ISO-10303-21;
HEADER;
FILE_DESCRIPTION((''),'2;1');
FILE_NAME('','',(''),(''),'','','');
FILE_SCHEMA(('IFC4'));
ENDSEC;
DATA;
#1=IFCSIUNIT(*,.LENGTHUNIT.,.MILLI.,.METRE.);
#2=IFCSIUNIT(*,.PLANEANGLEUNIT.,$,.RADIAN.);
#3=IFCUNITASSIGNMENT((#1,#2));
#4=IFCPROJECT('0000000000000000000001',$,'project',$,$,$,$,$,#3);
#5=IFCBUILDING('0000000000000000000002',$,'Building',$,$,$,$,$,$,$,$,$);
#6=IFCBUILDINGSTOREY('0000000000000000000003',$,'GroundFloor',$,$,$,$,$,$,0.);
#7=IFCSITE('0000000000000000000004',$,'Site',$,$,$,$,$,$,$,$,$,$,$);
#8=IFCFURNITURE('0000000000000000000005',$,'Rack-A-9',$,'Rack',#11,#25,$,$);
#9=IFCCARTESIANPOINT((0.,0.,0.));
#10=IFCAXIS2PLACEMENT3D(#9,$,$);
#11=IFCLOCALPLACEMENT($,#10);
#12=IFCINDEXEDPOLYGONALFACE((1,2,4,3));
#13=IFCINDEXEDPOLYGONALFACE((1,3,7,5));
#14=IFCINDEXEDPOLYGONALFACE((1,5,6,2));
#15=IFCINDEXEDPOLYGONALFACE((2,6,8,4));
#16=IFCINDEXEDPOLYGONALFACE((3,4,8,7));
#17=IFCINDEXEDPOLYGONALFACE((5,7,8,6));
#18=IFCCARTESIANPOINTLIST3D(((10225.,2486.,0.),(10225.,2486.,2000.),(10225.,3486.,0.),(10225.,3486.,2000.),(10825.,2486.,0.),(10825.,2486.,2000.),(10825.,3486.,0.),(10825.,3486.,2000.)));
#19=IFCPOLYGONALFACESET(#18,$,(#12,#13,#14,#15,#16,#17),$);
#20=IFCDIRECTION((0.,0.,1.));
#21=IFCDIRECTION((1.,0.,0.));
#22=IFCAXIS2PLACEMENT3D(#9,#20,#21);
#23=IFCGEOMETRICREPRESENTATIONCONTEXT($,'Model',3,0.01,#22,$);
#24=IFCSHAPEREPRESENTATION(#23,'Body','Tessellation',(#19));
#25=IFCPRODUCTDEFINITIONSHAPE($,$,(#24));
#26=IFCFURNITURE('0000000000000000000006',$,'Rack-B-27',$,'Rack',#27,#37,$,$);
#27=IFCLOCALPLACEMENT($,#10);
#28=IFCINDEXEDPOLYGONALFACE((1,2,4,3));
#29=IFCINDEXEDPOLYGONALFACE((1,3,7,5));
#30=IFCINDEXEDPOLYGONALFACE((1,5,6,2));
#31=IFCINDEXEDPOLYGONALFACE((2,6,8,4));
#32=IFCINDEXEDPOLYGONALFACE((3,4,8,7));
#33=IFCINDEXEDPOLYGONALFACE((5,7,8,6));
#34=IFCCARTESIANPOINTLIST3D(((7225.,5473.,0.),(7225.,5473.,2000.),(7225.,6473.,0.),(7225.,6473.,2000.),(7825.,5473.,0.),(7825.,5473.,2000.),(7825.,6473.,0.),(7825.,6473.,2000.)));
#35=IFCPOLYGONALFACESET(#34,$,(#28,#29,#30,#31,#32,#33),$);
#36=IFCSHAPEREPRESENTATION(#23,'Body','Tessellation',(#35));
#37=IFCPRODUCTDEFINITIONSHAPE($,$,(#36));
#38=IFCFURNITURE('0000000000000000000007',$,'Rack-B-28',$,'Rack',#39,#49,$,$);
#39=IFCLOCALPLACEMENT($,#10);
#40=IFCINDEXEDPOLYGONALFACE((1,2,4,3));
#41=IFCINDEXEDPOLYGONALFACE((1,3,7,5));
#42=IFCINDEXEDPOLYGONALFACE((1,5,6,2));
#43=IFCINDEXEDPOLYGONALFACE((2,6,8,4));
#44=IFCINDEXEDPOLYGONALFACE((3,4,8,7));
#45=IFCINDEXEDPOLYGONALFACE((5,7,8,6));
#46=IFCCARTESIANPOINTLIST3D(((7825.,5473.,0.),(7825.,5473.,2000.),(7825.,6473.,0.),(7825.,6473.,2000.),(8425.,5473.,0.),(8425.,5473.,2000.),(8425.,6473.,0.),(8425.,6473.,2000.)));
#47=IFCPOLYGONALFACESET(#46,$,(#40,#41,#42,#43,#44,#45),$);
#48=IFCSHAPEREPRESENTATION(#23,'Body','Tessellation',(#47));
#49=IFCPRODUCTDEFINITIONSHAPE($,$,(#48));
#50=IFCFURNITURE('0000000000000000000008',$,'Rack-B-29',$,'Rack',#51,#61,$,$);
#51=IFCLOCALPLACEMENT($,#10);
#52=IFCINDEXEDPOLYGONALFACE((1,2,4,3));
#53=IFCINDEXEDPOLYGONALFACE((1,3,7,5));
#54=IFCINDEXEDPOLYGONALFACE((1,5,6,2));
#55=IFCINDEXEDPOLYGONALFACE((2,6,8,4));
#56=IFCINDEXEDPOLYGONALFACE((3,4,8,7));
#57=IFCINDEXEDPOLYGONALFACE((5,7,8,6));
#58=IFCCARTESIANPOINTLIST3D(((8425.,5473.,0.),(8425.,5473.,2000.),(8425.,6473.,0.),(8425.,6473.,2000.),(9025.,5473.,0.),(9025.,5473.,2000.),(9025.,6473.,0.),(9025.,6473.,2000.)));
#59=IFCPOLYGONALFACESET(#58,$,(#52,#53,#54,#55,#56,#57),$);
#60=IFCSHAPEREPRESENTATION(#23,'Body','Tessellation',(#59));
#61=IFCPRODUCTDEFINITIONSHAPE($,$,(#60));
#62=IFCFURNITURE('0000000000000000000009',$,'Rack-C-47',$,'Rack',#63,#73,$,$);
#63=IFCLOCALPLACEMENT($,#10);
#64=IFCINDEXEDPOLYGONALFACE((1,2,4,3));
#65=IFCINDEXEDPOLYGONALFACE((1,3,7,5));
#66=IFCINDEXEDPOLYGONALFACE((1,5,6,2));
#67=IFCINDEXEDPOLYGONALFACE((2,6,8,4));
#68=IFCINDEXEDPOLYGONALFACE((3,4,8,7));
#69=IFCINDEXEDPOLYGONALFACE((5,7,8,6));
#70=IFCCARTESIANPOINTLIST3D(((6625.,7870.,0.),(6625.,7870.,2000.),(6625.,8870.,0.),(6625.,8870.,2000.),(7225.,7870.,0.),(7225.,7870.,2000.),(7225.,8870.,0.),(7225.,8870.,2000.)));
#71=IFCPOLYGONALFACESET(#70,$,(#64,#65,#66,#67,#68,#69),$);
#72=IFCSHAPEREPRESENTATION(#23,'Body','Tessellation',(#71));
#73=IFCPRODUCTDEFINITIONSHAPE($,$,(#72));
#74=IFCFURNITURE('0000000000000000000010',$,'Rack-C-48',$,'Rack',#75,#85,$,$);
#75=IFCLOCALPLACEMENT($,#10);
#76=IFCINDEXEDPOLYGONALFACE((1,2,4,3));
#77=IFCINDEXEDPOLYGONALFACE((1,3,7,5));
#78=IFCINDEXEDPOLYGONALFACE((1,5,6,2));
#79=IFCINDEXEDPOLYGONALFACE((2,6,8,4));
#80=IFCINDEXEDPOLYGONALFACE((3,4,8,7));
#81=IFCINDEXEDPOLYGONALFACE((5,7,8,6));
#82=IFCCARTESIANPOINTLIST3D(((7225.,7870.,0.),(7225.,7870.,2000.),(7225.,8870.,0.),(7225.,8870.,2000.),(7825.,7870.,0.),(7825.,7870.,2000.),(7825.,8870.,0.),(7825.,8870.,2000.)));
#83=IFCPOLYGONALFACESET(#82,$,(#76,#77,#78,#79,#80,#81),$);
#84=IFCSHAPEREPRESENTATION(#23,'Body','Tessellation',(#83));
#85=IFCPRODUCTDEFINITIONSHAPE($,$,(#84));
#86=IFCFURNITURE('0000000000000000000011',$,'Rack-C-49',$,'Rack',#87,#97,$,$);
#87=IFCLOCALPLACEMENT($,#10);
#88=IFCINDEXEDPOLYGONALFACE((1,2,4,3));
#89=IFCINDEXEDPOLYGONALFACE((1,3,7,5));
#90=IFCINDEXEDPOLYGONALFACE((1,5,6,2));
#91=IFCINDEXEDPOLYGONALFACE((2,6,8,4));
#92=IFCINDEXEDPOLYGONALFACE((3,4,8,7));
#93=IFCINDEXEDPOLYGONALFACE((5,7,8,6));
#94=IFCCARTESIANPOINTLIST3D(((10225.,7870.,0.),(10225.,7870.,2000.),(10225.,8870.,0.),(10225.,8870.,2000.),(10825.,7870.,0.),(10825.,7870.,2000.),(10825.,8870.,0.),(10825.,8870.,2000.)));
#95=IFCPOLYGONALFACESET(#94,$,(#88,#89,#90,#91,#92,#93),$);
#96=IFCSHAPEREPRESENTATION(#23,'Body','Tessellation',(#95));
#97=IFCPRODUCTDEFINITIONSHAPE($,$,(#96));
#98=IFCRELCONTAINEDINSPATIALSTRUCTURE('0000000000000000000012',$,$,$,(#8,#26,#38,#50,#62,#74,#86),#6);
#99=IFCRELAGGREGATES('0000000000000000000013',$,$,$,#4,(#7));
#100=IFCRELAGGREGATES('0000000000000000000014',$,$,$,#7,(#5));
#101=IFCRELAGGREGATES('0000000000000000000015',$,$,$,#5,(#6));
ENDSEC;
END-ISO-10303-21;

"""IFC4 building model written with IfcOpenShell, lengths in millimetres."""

from ifc_helpers import new_model, si_unit, frame, origin, origin_with_axes, origin_2d, place, context, project, spatial, rectangle, extrude, element, save


model = new_model("IFC4")

# Units and contexts
model_context = context("Model", 3, precision=0.01, world=origin_with_axes())
ifc_project = project(units=[si_unit("LENGTHUNIT", "METRE", prefix="MILLI"), si_unit("PLANEANGLEUNIT", "RADIAN")])

# Site, building, storey
site = spatial("IfcSite", under=ifc_project, Name="Site")
building = spatial("IfcBuilding", under=site, Name="Building")
storey = spatial("IfcBuildingStorey", under=building, Name="GroundFloor", Elevation=0.0)

# Furniture
for number, where, z_axis, x_axis, name in (
    (1, (10525.0, 2986.0, 0.0), (0.0, 0.0, 1.0), (1.0, 0.0, 0.0), "Rack-A-9"),
    (2, (7525.0, 5973.0, 0.0), (0.0, 0.0, 1.0), (1.0, 0.0, 0.0), "Rack-B-27"),
    (3, (8125.0, 5973.0, 0.0), (0.0, 0.0, 1.0), (1.0, 0.0, 0.0), "Rack-B-28"),
    (4, (8725.0, 5973.0, 0.0), (0.0, 0.0, 1.0), (1.0, 0.0, 0.0), "Rack-B-29"),
    (5, (6925.0, 8370.0, 0.0), (0.0, 0.0, 1.0), (1.0, 0.0, 0.0), "Rack-C-47"),
    (6, (7525.0, 8370.0, 0.0), (0.0, 0.0, 1.0), (1.0, 0.0, 0.0), "Rack-C-48"),
    (7, (10525.0, 8370.0, 0.0), (0.0, 0.0, 1.0), (1.0, 0.0, 0.0), "Rack-C-49"),
):
    element("IfcFurniture", number, at=place(None, frame(where, z_axis=z_axis, x_axis=x_axis)), inside=storey, Name=name, ObjectType="Rack", context=model_context, shape_type="SweptSolid", body=[
        extrude(rectangle(XDim=600.0, YDim=1000.0, at=origin_2d()), origin(), (0.0, 0.0, 1.0), 2000.0),
    ])

save(model, "model.ifc")
